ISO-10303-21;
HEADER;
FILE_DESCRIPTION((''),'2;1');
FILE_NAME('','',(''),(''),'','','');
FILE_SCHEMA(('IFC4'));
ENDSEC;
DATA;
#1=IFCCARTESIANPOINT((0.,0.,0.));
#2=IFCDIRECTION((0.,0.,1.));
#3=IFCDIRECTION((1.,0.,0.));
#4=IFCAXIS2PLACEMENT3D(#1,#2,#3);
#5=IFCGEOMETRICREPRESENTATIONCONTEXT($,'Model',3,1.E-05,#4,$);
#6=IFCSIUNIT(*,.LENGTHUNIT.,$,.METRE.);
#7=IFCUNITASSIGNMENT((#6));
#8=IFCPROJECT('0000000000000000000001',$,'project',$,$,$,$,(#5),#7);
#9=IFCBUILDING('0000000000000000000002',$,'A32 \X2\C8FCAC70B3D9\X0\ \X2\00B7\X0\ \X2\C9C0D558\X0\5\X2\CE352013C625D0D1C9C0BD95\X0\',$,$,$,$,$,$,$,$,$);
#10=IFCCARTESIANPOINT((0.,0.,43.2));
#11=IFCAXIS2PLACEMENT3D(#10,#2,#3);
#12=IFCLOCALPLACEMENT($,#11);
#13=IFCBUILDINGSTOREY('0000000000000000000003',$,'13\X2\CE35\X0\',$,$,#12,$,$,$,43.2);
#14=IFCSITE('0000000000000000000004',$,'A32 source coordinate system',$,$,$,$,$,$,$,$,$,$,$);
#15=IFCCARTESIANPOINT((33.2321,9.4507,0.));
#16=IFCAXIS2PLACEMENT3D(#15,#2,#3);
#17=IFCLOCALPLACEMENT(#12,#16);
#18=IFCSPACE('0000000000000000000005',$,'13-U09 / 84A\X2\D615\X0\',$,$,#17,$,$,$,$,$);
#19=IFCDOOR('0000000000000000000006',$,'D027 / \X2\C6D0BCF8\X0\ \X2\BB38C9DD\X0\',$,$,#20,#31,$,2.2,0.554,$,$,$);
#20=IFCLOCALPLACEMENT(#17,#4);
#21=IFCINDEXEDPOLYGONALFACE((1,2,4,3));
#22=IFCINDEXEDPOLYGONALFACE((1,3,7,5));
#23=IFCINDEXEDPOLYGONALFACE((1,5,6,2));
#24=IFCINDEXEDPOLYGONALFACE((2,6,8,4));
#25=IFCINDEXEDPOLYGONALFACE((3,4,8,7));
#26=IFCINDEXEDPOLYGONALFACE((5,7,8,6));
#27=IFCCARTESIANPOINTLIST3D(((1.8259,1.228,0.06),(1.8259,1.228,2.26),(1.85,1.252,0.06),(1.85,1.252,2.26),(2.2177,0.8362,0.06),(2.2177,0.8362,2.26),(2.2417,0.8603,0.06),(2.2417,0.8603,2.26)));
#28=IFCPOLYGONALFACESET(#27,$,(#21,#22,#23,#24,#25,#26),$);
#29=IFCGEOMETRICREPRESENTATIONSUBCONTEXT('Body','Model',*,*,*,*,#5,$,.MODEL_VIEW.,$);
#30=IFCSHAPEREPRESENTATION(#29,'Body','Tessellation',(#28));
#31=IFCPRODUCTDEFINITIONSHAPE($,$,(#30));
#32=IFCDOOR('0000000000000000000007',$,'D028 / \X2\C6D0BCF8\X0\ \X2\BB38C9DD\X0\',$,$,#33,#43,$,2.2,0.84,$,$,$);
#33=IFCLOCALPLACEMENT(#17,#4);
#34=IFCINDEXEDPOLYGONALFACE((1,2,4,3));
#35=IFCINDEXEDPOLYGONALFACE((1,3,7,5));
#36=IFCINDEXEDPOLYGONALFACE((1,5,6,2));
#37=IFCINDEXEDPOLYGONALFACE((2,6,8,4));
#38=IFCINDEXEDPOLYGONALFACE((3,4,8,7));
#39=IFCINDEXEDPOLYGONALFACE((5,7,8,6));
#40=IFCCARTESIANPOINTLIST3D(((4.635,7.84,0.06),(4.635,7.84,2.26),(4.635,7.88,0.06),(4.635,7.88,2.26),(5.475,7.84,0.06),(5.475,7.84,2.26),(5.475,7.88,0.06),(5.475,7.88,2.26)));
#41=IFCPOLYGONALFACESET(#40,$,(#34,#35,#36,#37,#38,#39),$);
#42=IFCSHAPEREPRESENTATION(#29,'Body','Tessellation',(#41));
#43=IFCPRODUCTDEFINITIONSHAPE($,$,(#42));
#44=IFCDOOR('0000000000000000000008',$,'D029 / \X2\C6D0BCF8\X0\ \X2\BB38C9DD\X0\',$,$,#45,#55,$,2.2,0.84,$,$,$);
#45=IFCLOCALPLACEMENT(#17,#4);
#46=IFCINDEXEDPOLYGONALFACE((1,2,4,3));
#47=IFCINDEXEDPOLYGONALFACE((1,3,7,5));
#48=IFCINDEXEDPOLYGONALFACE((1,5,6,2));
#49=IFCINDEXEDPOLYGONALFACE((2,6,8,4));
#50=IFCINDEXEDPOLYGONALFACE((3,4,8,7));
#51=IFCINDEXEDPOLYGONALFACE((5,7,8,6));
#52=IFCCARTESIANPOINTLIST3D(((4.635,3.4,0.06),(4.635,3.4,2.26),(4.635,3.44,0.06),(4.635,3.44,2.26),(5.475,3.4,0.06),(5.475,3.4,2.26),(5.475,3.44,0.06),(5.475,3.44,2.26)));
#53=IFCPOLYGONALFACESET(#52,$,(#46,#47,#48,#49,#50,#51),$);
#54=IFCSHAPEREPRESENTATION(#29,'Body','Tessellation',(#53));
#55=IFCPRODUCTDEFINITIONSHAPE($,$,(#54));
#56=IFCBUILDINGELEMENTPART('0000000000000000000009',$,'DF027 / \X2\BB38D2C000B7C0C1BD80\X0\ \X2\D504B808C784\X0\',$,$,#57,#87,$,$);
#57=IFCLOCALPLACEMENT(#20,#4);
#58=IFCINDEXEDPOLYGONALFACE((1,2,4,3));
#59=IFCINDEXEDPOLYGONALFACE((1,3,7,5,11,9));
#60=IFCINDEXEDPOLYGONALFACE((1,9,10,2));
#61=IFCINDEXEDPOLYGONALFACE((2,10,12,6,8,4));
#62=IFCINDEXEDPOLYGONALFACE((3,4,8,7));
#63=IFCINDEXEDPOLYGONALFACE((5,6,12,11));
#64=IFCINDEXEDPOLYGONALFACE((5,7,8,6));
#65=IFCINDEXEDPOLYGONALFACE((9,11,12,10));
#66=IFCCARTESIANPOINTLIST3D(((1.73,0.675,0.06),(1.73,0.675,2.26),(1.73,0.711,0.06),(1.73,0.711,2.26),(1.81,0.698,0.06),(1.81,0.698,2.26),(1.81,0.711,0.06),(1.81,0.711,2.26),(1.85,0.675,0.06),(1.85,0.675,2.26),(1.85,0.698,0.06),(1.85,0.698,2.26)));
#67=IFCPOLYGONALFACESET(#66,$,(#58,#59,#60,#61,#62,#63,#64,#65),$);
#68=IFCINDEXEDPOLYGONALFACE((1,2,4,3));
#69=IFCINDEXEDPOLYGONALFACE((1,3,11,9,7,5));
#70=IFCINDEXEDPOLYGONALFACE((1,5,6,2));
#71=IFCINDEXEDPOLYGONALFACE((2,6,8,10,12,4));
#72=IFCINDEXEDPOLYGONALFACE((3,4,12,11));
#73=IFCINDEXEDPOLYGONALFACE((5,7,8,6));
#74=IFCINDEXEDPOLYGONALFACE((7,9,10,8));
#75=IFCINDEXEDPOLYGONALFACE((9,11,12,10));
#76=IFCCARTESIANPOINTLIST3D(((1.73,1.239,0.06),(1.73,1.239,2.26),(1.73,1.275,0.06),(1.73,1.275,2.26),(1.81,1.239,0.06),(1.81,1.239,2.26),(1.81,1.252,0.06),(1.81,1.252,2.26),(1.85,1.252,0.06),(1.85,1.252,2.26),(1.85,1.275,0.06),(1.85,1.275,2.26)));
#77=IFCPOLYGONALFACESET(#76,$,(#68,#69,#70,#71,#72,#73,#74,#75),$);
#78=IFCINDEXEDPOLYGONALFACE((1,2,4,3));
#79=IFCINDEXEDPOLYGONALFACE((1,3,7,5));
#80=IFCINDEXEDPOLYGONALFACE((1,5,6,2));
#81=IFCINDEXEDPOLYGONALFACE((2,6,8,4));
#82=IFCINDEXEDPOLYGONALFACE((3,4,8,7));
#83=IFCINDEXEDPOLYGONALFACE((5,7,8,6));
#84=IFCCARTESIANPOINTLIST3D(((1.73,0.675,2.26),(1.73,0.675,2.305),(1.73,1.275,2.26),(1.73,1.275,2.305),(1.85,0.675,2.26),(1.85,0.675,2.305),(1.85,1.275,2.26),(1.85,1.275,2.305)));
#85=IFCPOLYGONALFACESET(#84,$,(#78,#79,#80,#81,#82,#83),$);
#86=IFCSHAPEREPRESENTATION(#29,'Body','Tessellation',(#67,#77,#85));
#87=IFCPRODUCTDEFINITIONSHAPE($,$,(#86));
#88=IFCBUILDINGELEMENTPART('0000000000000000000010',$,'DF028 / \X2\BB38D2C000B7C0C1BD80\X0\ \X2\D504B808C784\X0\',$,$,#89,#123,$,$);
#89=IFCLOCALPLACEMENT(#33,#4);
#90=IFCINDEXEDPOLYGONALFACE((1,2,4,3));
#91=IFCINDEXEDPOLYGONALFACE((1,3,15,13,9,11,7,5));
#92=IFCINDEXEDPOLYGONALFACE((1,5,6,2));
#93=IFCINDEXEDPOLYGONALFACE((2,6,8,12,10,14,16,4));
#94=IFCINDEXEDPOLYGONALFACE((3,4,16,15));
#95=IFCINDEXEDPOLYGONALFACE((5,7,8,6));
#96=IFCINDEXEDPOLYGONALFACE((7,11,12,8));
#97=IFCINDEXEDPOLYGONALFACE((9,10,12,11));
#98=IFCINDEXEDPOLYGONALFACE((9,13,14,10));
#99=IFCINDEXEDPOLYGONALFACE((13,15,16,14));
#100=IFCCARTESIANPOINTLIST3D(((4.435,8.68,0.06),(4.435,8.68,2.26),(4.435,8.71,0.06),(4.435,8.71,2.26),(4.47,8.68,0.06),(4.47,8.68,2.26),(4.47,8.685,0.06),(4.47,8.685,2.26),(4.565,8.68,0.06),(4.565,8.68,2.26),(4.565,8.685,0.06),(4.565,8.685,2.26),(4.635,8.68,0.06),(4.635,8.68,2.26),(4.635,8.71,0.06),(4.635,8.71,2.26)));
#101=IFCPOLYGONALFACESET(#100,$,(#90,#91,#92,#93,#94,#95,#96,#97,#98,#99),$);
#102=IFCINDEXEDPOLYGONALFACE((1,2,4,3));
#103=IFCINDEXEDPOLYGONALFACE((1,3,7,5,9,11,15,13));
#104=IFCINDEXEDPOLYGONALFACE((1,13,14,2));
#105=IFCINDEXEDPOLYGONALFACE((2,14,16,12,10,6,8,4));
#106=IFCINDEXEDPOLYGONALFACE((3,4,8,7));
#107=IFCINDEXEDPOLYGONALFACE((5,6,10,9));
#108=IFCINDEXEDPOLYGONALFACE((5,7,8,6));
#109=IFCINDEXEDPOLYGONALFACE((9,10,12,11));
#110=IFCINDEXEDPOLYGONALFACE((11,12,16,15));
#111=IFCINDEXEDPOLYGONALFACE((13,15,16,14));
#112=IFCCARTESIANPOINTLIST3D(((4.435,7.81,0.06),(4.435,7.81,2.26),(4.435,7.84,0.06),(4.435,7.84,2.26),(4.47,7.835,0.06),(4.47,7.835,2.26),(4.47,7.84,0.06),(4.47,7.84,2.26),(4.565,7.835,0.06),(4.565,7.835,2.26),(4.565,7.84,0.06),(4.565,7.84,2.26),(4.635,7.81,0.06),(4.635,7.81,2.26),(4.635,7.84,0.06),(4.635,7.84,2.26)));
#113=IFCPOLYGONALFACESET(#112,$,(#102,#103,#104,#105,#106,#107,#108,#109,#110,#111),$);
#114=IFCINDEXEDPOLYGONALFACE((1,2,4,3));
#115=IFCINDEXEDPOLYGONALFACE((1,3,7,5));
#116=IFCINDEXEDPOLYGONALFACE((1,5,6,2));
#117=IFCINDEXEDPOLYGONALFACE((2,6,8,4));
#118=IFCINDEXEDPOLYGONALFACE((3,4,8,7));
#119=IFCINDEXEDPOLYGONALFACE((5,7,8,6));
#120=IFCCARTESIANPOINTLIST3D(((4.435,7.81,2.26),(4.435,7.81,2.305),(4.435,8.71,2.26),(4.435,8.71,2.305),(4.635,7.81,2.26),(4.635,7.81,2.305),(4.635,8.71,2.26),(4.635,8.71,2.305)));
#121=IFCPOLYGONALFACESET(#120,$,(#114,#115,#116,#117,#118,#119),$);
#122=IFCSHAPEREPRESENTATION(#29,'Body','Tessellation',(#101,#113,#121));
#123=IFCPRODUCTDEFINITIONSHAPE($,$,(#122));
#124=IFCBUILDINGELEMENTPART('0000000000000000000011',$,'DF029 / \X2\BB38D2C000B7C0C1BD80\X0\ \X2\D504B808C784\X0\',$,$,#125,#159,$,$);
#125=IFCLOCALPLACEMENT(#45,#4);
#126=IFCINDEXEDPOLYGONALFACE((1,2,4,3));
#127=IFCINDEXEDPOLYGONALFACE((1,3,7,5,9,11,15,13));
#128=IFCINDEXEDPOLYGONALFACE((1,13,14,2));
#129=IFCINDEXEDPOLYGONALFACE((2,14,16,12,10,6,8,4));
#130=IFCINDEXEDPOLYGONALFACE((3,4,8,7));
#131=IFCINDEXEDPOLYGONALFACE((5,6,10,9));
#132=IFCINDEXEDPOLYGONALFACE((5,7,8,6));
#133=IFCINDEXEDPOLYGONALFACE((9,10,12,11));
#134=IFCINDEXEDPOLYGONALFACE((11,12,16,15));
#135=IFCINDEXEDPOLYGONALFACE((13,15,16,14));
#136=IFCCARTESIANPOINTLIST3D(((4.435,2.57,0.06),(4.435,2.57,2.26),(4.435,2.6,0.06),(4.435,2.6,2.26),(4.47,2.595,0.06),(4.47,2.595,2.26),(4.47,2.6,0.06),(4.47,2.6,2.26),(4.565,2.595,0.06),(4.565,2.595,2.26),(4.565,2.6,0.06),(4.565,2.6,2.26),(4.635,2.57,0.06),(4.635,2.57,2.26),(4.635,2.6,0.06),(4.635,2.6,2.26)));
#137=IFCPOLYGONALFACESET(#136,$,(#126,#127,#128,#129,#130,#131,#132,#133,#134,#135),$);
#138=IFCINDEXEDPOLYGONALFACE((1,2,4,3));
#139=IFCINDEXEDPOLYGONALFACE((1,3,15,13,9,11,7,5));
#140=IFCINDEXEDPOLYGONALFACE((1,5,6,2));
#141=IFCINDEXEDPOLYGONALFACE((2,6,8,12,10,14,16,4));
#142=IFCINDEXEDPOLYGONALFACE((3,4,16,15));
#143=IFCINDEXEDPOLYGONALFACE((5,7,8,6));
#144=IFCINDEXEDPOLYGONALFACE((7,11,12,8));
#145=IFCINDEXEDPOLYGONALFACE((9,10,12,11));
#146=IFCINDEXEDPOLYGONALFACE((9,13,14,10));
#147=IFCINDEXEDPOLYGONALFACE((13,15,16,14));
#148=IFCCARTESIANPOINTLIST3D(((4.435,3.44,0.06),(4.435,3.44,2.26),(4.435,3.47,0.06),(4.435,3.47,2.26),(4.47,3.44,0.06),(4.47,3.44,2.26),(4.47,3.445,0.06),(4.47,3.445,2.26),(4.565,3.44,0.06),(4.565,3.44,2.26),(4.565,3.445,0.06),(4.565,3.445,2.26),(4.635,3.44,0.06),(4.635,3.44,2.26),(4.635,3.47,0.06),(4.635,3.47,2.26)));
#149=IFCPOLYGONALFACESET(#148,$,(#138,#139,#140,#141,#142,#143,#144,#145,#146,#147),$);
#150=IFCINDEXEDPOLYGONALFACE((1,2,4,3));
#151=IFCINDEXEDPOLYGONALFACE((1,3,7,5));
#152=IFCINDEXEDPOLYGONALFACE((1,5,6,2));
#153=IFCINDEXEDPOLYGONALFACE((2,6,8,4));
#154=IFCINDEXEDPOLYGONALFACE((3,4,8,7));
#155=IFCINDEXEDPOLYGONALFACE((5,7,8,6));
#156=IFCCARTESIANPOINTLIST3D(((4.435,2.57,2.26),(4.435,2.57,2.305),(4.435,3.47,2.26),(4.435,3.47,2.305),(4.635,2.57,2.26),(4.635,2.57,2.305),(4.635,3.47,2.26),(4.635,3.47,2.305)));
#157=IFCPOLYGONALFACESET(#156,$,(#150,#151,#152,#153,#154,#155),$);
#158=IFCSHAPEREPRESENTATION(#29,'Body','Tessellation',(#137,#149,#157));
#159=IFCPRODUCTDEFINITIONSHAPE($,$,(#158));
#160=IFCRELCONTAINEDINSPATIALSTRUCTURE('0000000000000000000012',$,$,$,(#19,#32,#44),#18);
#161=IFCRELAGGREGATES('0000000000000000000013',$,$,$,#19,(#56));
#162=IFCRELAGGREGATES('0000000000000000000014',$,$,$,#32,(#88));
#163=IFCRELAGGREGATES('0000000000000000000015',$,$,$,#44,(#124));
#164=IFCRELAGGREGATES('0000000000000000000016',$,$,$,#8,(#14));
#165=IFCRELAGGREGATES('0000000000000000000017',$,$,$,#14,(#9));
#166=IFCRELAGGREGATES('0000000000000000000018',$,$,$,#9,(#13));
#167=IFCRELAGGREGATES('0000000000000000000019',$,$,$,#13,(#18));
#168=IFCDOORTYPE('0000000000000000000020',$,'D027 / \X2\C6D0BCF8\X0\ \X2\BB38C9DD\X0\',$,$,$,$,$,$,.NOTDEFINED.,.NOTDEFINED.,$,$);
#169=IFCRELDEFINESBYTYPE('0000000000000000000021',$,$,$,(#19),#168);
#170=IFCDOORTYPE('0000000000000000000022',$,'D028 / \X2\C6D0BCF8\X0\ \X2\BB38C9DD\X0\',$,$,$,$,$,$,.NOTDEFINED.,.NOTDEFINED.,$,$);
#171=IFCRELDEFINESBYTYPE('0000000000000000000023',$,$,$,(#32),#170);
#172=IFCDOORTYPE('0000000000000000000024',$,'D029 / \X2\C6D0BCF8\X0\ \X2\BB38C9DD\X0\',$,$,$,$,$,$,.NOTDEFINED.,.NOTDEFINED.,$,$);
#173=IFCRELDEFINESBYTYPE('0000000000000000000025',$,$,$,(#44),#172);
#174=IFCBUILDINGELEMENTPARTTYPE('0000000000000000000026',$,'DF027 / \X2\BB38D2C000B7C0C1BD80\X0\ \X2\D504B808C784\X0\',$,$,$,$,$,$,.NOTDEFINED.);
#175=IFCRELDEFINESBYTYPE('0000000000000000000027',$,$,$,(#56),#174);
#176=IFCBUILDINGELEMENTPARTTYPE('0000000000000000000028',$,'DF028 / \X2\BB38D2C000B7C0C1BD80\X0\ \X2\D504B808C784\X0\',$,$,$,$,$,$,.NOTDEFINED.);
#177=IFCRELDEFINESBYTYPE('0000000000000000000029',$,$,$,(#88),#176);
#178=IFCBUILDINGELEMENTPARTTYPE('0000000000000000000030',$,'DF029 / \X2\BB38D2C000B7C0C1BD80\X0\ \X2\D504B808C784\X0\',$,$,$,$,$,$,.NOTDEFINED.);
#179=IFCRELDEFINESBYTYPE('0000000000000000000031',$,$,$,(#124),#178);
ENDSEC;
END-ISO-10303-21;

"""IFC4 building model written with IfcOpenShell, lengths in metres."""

from ifc_helpers import new_model, si_unit, frame, origin, origin_with_axes, place, context, subcontext, project, spatial, polyline, outline, extrude, source, transform, mapped, type_object, type_shapes, element, aggregate, save


model = new_model("IFC4")

# Units and contexts
model_context = context("Model", 3, precision=1e-05, world=origin_with_axes())
body_context = subcontext(model_context, "Body", "Model", "MODEL_VIEW")
ifc_project = project(units=[si_unit("LENGTHUNIT", "METRE")], contexts=[model_context])

# Site, building, storey, space
storey_placement = place(None, frame((0.0, 0.0, 43.2), z_axis=(0.0, 0.0, 1.0), x_axis=(1.0, 0.0, 0.0)))
space_placement = place(storey_placement, frame((33.2321, 9.4507, 0.0), z_axis=(0.0, 0.0, 1.0), x_axis=(1.0, 0.0, 0.0)))
site = spatial("IfcSite", under=ifc_project, Name="A32 source coordinate system")
building = spatial("IfcBuilding", under=site, Name="A32 주거동 · 지하5층–옥탑지붕")
storey = spatial("IfcBuildingStorey", under=building, at=storey_placement, Name="13층", Elevation=43.2)
space = spatial("IfcSpace", under=storey, at=space_placement, Name="13-U09 / 84A형")

# Doors
door_type_1 = type_object("IfcDoorType", Name="D027 / 원본 문짝", OperationType="NOTDEFINED", PredefinedType="NOTDEFINED")
shared_shape_1 = source(origin(), body_context, "Body", "SweptSolid", [
    extrude(outline(polyline([(1.85, 1.252), (2.2417, 0.8603), (2.2177, 0.8362), (1.8259, 1.228), (1.85, 1.252)])), frame((0.0, 0.0, 0.06)), (0.0, 0.0, 1.0), 2.2),
])
type_shapes(door_type_1, [shared_shape_1])
door_1_placement = place(space_placement, origin_with_axes())
door_1 = element("IfcDoor", 1, at=door_1_placement, inside=space, type_object=door_type_1, Name="D027 / 원본 문짝", OverallHeight=2.2, OverallWidth=0.554, context=body_context, shape_type="MappedRepresentation", body=[
    mapped(shared_shape_1, transform((0.0, 0.0, 0.0), scale=1.0)),
])
door_type_2 = type_object("IfcDoorType", Name="D028 / 원본 문짝", OperationType="NOTDEFINED", PredefinedType="NOTDEFINED")
shared_shape_2 = source(origin(), body_context, "Body", "SweptSolid", [
    extrude(outline(polyline([(5.475, 7.88), (5.475, 7.84), (4.635, 7.84), (4.635, 7.88), (5.475, 7.88)])), frame((0.0, 0.0, 0.06)), (0.0, 0.0, 1.0), 2.2),
])
type_shapes(door_type_2, [shared_shape_2])
door_2_placement = place(space_placement, origin_with_axes())
door_2 = element("IfcDoor", 2, at=door_2_placement, inside=space, type_object=door_type_2, Name="D028 / 원본 문짝", OverallHeight=2.2, OverallWidth=0.84, context=body_context, shape_type="MappedRepresentation", body=[
    mapped(shared_shape_2, transform((0.0, 0.0, 0.0), scale=1.0)),
])
door_type_3 = type_object("IfcDoorType", Name="D029 / 원본 문짝", OperationType="NOTDEFINED", PredefinedType="NOTDEFINED")
shared_shape_3 = source(origin(), body_context, "Body", "SweptSolid", [
    extrude(outline(polyline([(4.635, 3.44), (5.475, 3.44), (5.475, 3.4), (4.635, 3.4), (4.635, 3.44)])), frame((0.0, 0.0, 0.06)), (0.0, 0.0, 1.0), 2.2),
])
type_shapes(door_type_3, [shared_shape_3])
door_3_placement = place(space_placement, origin_with_axes())
door_3 = element("IfcDoor", 3, at=door_3_placement, inside=space, type_object=door_type_3, Name="D029 / 원본 문짝", OverallHeight=2.2, OverallWidth=0.84, context=body_context, shape_type="MappedRepresentation", body=[
    mapped(shared_shape_3, transform((0.0, 0.0, 0.0), scale=1.0)),
])

# Building element parts
building_element_part_type_1 = type_object("IfcBuildingElementPartType", Name="DF027 / 문틀·상부 프레임", PredefinedType="NOTDEFINED")
shared_shape_4 = source(origin(), body_context, "Body", "SweptSolid", [
    extrude(outline(polyline([(1.73, 0.711), (1.81, 0.711), (1.81, 0.698), (1.85, 0.698), (1.85, 0.675), (1.73, 0.675), (1.73, 0.711)])), frame((0.0, 0.0, 0.06)), (0.0, 0.0, 1.0), 2.2),
    extrude(outline(polyline([(1.85, 1.275), (1.85, 1.252), (1.81, 1.252), (1.81, 1.239), (1.73, 1.239), (1.73, 1.275), (1.85, 1.275)])), frame((0.0, 0.0, 0.06)), (0.0, 0.0, 1.0), 2.2),
    extrude(outline(polyline([(1.73, 0.675), (1.73, 1.275), (1.85, 1.275), (1.85, 0.675), (1.73, 0.675)])), frame((0.0, 0.0, 2.26)), (0.0, 0.0, 1.0), 0.045),
])
type_shapes(building_element_part_type_1, [shared_shape_4])
building_element_part_1_placement = place(door_1_placement, origin_with_axes())
building_element_part_1 = element("IfcBuildingElementPart", 4, at=building_element_part_1_placement, type_object=building_element_part_type_1, Name="DF027 / 문틀·상부 프레임", context=body_context, shape_type="MappedRepresentation", body=[
    mapped(shared_shape_4, transform((0.0, 0.0, 0.0), scale=1.0)),
])
aggregate(door_1, [building_element_part_1])
building_element_part_type_2 = type_object("IfcBuildingElementPartType", Name="DF028 / 문틀·상부 프레임", PredefinedType="NOTDEFINED")
shared_shape_5 = source(origin(), body_context, "Body", "SweptSolid", [
    extrude(outline(polyline([(4.635, 8.68), (4.565, 8.68), (4.565, 8.685), (4.47, 8.685), (4.47, 8.68), (4.435, 8.68), (4.435, 8.71), (4.635, 8.71), (4.635, 8.68)])), frame((0.0, 0.0, 0.06)), (0.0, 0.0, 1.0), 2.2),
    extrude(outline(polyline([(4.435, 7.81), (4.435, 7.84), (4.47, 7.84), (4.47, 7.835), (4.565, 7.835), (4.565, 7.84), (4.635, 7.84), (4.635, 7.81), (4.435, 7.81)])), frame((0.0, 0.0, 0.06)), (0.0, 0.0, 1.0), 2.2),
    extrude(outline(polyline([(4.435, 7.81), (4.435, 8.71), (4.635, 8.71), (4.635, 7.81), (4.435, 7.81)])), frame((0.0, 0.0, 2.26)), (0.0, 0.0, 1.0), 0.045),
])
type_shapes(building_element_part_type_2, [shared_shape_5])
building_element_part_2_placement = place(door_2_placement, origin_with_axes())
building_element_part_2 = element("IfcBuildingElementPart", 5, at=building_element_part_2_placement, type_object=building_element_part_type_2, Name="DF028 / 문틀·상부 프레임", context=body_context, shape_type="MappedRepresentation", body=[
    mapped(shared_shape_5, transform((0.0, 0.0, 0.0), scale=1.0)),
])
aggregate(door_2, [building_element_part_2])
building_element_part_type_3 = type_object("IfcBuildingElementPartType", Name="DF029 / 문틀·상부 프레임", PredefinedType="NOTDEFINED")
shared_shape_6 = source(origin(), body_context, "Body", "SweptSolid", [
    extrude(outline(polyline([(4.435, 2.57), (4.435, 2.6), (4.47, 2.6), (4.47, 2.595), (4.565, 2.595), (4.565, 2.6), (4.635, 2.6), (4.635, 2.57), (4.435, 2.57)])), frame((0.0, 0.0, 0.06)), (0.0, 0.0, 1.0), 2.2),
    extrude(outline(polyline([(4.635, 3.44), (4.565, 3.44), (4.565, 3.445), (4.47, 3.445), (4.47, 3.44), (4.435, 3.44), (4.435, 3.47), (4.635, 3.47), (4.635, 3.44)])), frame((0.0, 0.0, 0.06)), (0.0, 0.0, 1.0), 2.2),
    extrude(outline(polyline([(4.435, 2.57), (4.435, 3.47), (4.635, 3.47), (4.635, 2.57), (4.435, 2.57)])), frame((0.0, 0.0, 2.26)), (0.0, 0.0, 1.0), 0.045),
])
type_shapes(building_element_part_type_3, [shared_shape_6])
building_element_part_3_placement = place(door_3_placement, origin_with_axes())
building_element_part_3 = element("IfcBuildingElementPart", 6, at=building_element_part_3_placement, type_object=building_element_part_type_3, Name="DF029 / 문틀·상부 프레임", context=body_context, shape_type="MappedRepresentation", body=[
    mapped(shared_shape_6, transform((0.0, 0.0, 0.0), scale=1.0)),
])
aggregate(door_3, [building_element_part_3])

save(model, "model.ifc")
